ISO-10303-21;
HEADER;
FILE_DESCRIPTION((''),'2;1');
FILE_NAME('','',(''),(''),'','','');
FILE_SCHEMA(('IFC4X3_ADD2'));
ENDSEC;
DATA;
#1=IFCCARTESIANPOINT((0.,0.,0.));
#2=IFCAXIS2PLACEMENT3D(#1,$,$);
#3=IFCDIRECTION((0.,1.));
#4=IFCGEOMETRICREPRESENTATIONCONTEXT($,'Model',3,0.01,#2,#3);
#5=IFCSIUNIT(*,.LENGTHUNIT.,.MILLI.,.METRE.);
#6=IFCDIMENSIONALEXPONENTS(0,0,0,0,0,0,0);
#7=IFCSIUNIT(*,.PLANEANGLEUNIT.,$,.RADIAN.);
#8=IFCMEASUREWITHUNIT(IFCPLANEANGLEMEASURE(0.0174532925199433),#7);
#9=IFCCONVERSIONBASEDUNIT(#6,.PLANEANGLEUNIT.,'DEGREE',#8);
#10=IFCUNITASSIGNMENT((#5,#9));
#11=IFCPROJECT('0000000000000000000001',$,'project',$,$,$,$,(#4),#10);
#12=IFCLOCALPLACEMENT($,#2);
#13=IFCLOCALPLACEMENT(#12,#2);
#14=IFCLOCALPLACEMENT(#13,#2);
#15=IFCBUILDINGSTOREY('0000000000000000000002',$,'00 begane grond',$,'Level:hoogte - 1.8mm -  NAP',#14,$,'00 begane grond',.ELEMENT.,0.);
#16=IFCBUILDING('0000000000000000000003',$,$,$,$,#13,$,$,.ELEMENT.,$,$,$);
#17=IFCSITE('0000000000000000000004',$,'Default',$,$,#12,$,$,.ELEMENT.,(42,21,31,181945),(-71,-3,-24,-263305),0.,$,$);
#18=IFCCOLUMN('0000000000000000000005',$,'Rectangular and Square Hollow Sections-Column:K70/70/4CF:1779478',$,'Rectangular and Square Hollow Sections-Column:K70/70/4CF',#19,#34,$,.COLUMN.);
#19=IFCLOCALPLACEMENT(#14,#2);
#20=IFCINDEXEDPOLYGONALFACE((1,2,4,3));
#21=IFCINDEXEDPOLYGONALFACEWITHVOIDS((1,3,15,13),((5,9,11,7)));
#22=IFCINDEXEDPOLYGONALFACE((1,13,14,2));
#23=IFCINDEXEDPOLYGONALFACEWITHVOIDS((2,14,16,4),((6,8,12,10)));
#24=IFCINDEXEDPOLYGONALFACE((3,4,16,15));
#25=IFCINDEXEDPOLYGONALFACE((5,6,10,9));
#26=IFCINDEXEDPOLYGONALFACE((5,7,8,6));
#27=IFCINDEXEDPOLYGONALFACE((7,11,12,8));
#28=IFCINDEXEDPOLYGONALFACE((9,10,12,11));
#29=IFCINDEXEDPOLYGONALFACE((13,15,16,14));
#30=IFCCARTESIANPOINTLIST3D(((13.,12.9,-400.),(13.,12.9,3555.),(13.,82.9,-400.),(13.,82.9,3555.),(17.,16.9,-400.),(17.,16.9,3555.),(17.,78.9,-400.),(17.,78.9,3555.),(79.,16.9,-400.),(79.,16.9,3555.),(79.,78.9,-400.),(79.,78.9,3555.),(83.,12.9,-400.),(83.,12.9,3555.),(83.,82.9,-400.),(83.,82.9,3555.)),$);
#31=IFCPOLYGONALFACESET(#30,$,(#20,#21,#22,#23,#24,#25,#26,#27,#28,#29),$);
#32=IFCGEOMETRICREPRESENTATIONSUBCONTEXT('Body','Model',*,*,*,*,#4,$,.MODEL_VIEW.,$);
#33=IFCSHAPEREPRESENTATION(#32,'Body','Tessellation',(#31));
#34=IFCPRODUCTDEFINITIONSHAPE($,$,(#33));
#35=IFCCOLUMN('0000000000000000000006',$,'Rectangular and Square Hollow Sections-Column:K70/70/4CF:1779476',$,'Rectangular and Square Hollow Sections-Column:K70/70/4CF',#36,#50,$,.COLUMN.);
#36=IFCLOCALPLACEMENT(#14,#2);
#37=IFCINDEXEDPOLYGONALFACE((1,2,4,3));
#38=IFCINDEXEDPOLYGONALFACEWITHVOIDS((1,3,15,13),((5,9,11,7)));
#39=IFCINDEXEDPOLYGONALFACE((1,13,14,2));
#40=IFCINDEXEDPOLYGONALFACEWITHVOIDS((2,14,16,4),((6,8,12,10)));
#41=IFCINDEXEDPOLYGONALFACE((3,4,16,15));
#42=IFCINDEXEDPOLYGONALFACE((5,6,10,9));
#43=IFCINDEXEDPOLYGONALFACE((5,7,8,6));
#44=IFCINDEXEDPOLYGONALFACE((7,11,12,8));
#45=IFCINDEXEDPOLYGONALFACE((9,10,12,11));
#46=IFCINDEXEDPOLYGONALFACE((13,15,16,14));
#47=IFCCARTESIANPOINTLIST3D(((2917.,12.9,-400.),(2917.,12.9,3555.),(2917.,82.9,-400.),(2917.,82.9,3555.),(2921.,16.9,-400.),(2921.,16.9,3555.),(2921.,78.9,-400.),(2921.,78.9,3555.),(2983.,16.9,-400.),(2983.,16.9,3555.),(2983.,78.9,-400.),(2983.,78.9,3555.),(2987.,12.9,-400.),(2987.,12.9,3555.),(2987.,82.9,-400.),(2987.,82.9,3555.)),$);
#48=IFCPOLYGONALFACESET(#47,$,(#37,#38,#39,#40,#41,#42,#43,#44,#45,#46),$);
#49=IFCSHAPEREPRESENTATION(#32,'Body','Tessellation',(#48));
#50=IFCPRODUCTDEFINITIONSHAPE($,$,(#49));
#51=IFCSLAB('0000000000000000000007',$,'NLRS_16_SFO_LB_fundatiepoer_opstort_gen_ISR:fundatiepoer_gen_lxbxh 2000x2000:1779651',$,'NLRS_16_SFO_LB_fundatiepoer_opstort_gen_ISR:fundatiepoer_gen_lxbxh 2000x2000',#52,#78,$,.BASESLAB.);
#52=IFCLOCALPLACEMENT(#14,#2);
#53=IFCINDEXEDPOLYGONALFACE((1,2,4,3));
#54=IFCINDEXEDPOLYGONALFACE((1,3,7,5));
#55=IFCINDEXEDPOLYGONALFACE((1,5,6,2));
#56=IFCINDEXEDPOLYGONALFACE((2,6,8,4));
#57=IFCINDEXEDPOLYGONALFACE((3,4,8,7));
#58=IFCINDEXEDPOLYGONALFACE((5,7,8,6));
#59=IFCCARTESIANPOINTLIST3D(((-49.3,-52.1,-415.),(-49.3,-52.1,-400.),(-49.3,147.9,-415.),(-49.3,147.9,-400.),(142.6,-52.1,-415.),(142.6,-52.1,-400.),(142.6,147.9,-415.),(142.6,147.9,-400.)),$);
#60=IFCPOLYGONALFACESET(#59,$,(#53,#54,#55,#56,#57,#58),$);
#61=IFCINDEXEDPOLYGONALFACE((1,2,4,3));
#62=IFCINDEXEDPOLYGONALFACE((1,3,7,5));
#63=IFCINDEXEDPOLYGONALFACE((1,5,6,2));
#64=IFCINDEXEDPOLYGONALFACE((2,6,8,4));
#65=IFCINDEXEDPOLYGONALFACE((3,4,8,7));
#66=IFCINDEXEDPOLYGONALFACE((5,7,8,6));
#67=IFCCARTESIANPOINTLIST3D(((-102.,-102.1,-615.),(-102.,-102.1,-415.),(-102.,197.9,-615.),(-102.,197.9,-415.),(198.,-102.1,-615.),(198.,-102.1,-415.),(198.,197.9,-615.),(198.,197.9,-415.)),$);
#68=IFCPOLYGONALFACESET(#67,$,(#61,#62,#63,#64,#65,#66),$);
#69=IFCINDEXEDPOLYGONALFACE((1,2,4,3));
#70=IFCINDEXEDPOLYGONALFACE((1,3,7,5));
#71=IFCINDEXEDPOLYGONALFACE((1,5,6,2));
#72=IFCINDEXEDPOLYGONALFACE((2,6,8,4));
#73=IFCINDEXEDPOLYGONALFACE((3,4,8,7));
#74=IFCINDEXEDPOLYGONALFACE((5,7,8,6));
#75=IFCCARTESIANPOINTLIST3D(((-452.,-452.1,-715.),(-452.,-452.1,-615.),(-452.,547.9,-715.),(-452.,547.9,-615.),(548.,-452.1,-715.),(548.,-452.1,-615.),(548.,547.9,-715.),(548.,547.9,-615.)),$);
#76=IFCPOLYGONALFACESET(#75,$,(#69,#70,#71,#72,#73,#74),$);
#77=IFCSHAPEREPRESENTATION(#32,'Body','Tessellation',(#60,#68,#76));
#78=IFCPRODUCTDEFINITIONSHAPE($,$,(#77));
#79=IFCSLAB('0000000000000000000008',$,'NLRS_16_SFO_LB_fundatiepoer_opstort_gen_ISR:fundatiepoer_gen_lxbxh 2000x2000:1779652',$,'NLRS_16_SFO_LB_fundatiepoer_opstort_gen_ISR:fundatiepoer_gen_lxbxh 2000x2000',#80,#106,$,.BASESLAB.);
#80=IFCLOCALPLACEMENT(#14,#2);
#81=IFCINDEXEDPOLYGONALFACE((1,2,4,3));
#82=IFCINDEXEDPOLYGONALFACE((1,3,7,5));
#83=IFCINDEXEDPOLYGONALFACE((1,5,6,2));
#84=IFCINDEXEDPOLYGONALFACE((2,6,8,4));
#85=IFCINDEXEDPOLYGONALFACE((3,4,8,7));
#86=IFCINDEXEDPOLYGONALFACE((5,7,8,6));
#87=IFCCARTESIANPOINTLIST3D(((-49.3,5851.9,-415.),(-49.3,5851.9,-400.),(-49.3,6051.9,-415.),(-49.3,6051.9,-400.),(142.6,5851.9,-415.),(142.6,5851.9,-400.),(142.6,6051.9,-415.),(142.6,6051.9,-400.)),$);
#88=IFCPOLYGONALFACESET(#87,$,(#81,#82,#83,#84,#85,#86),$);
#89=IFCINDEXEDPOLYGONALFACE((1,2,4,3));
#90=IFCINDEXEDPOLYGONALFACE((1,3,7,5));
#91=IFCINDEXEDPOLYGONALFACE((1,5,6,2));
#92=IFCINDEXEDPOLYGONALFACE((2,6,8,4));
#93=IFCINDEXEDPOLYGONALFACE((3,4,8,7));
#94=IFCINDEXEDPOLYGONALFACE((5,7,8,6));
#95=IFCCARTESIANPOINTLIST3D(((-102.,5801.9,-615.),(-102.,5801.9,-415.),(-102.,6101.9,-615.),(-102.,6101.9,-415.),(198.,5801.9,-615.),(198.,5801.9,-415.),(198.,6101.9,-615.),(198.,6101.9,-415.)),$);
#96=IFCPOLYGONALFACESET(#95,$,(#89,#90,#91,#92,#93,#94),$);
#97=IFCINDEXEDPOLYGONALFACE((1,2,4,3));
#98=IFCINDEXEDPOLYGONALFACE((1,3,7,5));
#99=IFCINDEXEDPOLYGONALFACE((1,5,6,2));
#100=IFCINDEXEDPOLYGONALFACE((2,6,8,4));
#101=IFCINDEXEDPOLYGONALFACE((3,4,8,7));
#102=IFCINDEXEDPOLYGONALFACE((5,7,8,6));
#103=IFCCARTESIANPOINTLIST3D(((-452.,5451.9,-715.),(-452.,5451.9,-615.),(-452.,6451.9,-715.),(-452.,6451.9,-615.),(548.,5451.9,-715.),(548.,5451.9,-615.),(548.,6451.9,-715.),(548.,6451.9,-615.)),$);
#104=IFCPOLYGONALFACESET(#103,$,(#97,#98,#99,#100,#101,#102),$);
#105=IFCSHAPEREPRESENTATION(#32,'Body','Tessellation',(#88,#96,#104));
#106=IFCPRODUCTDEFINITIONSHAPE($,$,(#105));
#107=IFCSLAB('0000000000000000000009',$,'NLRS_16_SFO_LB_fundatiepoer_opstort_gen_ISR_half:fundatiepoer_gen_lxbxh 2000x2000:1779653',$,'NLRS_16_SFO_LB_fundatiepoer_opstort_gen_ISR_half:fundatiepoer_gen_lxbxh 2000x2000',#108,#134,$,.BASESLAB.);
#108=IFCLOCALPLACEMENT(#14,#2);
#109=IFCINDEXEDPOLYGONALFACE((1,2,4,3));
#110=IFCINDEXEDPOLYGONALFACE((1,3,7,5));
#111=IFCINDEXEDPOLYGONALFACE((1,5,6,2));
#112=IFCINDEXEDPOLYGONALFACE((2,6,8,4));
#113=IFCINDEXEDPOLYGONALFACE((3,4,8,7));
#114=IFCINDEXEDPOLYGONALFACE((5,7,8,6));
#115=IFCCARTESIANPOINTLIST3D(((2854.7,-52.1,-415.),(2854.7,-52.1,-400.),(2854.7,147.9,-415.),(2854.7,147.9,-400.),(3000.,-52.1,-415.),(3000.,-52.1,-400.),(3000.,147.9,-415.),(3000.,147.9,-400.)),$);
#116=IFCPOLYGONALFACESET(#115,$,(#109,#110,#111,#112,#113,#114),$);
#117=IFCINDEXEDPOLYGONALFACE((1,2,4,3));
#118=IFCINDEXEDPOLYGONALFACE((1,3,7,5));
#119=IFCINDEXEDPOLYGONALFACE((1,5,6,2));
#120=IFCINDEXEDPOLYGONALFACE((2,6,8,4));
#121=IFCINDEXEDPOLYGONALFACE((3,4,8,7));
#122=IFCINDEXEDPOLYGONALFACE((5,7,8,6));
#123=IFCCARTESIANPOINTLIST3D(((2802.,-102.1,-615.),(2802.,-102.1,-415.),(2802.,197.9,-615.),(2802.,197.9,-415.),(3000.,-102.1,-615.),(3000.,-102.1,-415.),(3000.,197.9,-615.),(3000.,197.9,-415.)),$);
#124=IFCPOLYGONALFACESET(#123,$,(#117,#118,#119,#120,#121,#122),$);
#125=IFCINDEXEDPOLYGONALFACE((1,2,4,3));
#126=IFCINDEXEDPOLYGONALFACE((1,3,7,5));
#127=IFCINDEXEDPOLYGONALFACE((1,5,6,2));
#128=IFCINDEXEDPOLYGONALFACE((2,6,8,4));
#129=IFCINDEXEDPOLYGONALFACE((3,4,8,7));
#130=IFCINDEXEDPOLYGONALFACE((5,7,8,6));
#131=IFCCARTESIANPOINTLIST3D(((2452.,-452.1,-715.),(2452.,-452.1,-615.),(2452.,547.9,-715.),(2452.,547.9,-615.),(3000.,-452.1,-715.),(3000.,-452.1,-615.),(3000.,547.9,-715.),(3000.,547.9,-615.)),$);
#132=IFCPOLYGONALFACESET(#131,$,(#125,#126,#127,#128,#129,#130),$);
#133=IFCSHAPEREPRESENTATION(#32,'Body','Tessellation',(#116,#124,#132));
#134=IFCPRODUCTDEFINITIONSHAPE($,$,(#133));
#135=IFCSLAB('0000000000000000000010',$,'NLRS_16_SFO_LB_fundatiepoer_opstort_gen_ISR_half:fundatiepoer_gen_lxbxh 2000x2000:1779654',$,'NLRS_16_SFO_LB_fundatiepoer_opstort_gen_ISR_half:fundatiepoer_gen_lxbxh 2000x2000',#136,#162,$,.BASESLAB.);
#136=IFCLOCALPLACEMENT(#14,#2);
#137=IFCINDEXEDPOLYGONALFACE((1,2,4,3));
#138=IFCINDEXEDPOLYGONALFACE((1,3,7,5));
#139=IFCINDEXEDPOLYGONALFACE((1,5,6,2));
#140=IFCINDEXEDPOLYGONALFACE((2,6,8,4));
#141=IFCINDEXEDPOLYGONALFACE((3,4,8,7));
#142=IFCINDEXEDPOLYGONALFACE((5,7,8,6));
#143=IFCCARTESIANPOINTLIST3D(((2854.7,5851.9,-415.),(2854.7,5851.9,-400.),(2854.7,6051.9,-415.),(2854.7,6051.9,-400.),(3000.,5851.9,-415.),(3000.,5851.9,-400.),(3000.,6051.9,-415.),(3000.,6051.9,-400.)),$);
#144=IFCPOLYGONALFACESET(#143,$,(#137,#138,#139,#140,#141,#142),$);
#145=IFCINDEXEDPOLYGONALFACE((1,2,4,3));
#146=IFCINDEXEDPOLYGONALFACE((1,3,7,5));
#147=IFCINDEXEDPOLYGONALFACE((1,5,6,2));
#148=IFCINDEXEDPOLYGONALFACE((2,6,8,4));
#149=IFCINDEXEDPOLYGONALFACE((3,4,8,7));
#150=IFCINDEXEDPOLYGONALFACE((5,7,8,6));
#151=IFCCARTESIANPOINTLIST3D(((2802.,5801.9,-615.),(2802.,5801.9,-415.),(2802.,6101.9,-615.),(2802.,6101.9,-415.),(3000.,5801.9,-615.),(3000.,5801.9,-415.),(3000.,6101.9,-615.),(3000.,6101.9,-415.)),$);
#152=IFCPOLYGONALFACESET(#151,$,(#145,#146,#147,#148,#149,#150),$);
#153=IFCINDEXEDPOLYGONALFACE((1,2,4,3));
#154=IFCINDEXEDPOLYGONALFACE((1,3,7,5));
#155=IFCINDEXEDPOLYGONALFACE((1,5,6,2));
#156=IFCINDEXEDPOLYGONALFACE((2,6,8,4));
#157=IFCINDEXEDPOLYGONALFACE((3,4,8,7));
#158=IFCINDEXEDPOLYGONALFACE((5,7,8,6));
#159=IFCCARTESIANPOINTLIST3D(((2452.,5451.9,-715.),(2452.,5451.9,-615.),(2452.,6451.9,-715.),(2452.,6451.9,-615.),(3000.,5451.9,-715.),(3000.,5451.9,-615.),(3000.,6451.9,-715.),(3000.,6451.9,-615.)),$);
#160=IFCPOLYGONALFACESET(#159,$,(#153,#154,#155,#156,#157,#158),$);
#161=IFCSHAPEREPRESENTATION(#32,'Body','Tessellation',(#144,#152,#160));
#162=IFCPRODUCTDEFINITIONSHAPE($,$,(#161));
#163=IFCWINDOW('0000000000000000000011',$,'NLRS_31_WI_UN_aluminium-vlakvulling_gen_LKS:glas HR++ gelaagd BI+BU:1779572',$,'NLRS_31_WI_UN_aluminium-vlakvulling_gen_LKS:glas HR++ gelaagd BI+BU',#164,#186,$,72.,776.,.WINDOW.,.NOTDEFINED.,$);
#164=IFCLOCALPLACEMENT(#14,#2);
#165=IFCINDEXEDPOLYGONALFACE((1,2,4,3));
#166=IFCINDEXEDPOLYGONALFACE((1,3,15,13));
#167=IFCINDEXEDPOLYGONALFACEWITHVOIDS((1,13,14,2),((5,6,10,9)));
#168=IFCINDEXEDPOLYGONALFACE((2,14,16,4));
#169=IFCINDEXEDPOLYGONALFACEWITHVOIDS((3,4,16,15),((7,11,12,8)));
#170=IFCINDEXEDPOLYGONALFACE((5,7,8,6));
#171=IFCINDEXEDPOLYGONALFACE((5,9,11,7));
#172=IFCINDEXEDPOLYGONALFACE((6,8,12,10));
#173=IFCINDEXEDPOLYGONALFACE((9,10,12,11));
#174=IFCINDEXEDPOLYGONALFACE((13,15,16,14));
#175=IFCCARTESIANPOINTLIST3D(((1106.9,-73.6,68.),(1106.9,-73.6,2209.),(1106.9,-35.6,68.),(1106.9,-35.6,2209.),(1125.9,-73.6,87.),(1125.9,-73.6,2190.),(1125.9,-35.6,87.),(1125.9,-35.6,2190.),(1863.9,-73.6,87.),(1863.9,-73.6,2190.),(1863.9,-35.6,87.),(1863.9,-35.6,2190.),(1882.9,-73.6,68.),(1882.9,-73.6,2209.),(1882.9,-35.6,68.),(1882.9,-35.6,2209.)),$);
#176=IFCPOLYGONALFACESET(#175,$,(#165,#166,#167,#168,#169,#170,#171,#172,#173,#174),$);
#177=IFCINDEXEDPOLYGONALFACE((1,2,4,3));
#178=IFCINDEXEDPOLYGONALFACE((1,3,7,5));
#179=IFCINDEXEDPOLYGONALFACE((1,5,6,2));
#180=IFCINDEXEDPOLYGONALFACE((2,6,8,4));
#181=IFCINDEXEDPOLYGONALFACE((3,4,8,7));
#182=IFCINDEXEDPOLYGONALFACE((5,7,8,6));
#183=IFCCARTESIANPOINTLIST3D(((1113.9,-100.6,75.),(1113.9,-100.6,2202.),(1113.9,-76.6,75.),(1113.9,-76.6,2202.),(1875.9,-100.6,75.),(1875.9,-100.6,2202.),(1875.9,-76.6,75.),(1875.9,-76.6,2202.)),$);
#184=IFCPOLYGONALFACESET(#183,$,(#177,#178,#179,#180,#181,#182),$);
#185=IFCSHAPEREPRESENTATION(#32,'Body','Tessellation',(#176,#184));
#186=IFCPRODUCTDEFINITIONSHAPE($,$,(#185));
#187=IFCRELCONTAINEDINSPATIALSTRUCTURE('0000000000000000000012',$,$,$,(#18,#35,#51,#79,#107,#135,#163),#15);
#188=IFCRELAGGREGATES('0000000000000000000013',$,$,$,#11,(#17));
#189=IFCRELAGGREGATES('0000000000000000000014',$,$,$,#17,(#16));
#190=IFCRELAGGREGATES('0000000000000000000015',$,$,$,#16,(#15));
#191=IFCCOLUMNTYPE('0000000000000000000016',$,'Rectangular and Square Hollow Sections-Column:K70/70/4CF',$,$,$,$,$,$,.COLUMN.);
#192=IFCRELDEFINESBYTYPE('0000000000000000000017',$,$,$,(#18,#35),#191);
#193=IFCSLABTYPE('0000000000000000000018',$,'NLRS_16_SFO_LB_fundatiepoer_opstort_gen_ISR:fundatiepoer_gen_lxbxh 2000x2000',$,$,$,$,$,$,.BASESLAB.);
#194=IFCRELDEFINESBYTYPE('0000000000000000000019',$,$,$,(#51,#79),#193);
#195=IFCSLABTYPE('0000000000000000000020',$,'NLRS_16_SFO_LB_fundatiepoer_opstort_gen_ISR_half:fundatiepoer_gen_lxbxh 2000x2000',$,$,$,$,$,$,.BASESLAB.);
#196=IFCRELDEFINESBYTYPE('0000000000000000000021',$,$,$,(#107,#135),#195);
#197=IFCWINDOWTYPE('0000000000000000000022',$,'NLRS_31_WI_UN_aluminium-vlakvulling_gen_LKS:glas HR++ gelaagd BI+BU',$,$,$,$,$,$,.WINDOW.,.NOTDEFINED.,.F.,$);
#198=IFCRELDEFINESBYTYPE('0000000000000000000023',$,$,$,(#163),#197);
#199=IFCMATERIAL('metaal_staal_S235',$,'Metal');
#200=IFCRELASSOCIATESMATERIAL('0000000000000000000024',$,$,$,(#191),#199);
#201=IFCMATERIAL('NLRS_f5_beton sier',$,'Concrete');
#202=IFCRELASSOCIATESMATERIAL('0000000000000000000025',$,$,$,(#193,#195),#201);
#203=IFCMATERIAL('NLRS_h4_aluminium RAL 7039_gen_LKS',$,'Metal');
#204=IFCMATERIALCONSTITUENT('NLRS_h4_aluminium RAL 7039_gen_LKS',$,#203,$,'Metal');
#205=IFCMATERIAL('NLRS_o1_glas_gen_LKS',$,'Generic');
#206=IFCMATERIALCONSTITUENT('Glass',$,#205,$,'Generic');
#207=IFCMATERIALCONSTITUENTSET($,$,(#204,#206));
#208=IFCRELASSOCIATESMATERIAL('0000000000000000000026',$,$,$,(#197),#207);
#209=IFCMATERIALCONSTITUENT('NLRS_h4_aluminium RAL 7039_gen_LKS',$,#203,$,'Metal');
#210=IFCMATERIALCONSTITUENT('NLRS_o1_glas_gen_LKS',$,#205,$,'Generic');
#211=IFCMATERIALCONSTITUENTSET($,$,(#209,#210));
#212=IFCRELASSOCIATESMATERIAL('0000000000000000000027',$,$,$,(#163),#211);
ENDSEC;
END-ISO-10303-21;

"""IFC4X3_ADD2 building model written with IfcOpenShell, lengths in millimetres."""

from ifc_helpers import new_model, entity, si_unit, converted_unit, direction, frame, frame_2d, origin, origin_2d_with_axis, place, context, subcontext, project, spatial, polyline, rectangle, outline, extrude, source, transform, mapped, material, constituent, constituent_set, material_profile, profile_set, type_object, type_shapes, element, save


model = new_model("IFC4X3_ADD2")

# Units and contexts
model_context = context("Model", 3, precision=0.01, world=origin(), true_north=direction((0.0, 1.0)))
body_context = subcontext(model_context, "Body", "Model", "MODEL_VIEW")
ifc_project = project(units=[si_unit("LENGTHUNIT", "METRE", prefix="MILLI"), converted_unit("PLANEANGLEUNIT", "DEGREE", entity("IfcPlaneAngleMeasure", 0.0174532925199433), si_unit("PLANEANGLEUNIT", "RADIAN"), dimensions=[0, 0, 0, 0, 0, 0, 0])], contexts=[model_context])

# Site, building, storey
site_placement = place(None, origin())
site = spatial("IfcSite", under=ifc_project, at=site_placement, Name="Default", CompositionType="ELEMENT", RefLatitude=(42, 21, 31, 181945), RefLongitude=(-71, -3, -24, -263305), RefElevation=0.0)
building_placement = place(site_placement, origin())
building = spatial("IfcBuilding", under=site, at=building_placement, CompositionType="ELEMENT")
storey_placement = place(building_placement, origin())
storey = spatial("IfcBuildingStorey", under=building, at=storey_placement, Name="00 begane grond", ObjectType="Level:hoogte - 1.8mm -  NAP", LongName="00 begane grond", CompositionType="ELEMENT", Elevation=0.0)

# Columns
ifc_material_1 = material(Name="metaal_staal_S235", Category="Metal")
ifc_material_profile_1 = material_profile(ifc_material_1, outline(polyline([(-35.0, -35.0), (35.0, -35.0), (35.0, 35.0), (-35.0, 35.0), (-35.0, -35.0)]), holes=[polyline([(-31.0, -31.0), (-31.0, 31.0), (31.0, 31.0), (31.0, -31.0), (-31.0, -31.0)])]), Name="K70/70/4CF")
ifc_profile_set_1 = profile_set([ifc_material_profile_1], Name="K70/70/4CF")
column_type = type_object("IfcColumnType", Name="Rectangular and Square Hollow Sections-Column:K70/70/4CF", PredefinedType="COLUMN", material=ifc_profile_set_1)
shared_shape_1 = source(origin(), body_context, "Body", "SweptSolid", [
    extrude(outline(polyline([(-35.0, -35.0), (35.0, -35.0), (35.0, 35.0), (-35.0, 35.0), (-35.0, -35.0)]), holes=[polyline([(-31.0, -31.0), (-31.0, 31.0), (31.0, 31.0), (31.0, -31.0), (-31.0, -31.0)])]), frame((0.0, 0.0, -400.0), z_axis=(0.0, 0.0, 1.0), x_axis=(-1.0, 0.0, 0.0)), (0.0, 0.0, 1.0), 3955.0),
])
type_shapes(column_type, [shared_shape_1])
for number, where, z_axis, x_axis, name in (
    (1, (48.0, 47.9, 0.0), (0.0, 0.0, 1.0), (0.0, -1.0, 0.0), "Rectangular and Square Hollow Sections-Column:K70/70/4CF:1779478"),
    (2, (2952.0, 47.9, 0.0), (0.0, 0.0, 1.0), (0.0, -1.0, 0.0), "Rectangular and Square Hollow Sections-Column:K70/70/4CF:1779476"),
):
    element("IfcColumn", number, at=place(storey_placement, frame(where, z_axis=z_axis, x_axis=x_axis)), inside=storey, type_object=column_type, Name=name, ObjectType="Rectangular and Square Hollow Sections-Column:K70/70/4CF", PredefinedType="COLUMN", context=body_context, shape_type="MappedRepresentation", body=[
        mapped(shared_shape_1, transform((0.0, 0.0, 0.0), scale=1.0)),
    ])

# Slabs
ifc_material_2 = material(Name="NLRS_f5_beton sier", Category="Concrete")
slab_type_1 = type_object("IfcSlabType", Name="NLRS_16_SFO_LB_fundatiepoer_opstort_gen_ISR:fundatiepoer_gen_lxbxh 2000x2000", PredefinedType="BASESLAB", material=ifc_material_2)
slab_1_placement = place(storey_placement, frame((0.0, 0.0, -615.0)))
element("IfcSlab", 3, at=slab_1_placement, inside=storey, type_object=slab_type_1, Name="NLRS_16_SFO_LB_fundatiepoer_opstort_gen_ISR:fundatiepoer_gen_lxbxh 2000x2000:1779651", ObjectType="NLRS_16_SFO_LB_fundatiepoer_opstort_gen_ISR:fundatiepoer_gen_lxbxh 2000x2000", PredefinedType="BASESLAB", context=body_context, shape_type="SweptSolid", body=[
    extrude(rectangle(XDim=191.9, YDim=200.0, at=origin_2d_with_axis()), frame((46.6, 47.9, 200.0), z_axis=(0.0, 0.0, 1.0), x_axis=(-1.0, 0.0, 0.0)), (0.0, 0.0, 1.0), 15.0),
    extrude(rectangle(XDim=300.0, YDim=300.0, at=origin_2d_with_axis()), frame((48.0, 47.9, 0.0), z_axis=(0.0, 0.0, 1.0), x_axis=(-1.0, 0.0, 0.0)), (0.0, 0.0, 1.0), 200.0),
    extrude(rectangle(XDim=1000.0, YDim=1000.0, at=origin_2d_with_axis()), frame((48.0, 47.9, -100.0), z_axis=(0.0, 0.0, 1.0), x_axis=(-1.0, 0.0, 0.0)), (0.0, 0.0, 1.0), 100.0),
])
slab_2_placement = place(storey_placement, frame((0.0, 0.0, -615.0)))
element("IfcSlab", 4, at=slab_2_placement, inside=storey, type_object=slab_type_1, Name="NLRS_16_SFO_LB_fundatiepoer_opstort_gen_ISR:fundatiepoer_gen_lxbxh 2000x2000:1779652", ObjectType="NLRS_16_SFO_LB_fundatiepoer_opstort_gen_ISR:fundatiepoer_gen_lxbxh 2000x2000", PredefinedType="BASESLAB", context=body_context, shape_type="SweptSolid", body=[
    extrude(rectangle(XDim=200.0, YDim=191.9, at=frame_2d((0.0, 0.0), x_axis=(1.0, 0.0))), frame((46.6, 5951.9, 200.0), z_axis=(0.0, 0.0, 1.0), x_axis=(0.0, 1.0, 0.0)), (0.0, 0.0, 1.0), 15.0),
    extrude(rectangle(XDim=300.0, YDim=300.0, at=frame_2d((0.0, 0.0), x_axis=(1.0, 0.0))), frame((48.0, 5951.9, 0.0), z_axis=(0.0, 0.0, 1.0), x_axis=(0.0, 1.0, 0.0)), (0.0, 0.0, 1.0), 200.0),
    extrude(rectangle(XDim=1000.0, YDim=1000.0, at=frame_2d((0.0, 0.0), x_axis=(1.0, 0.0))), frame((48.0, 5951.9, -100.0), z_axis=(0.0, 0.0, 1.0), x_axis=(0.0, 1.0, 0.0)), (0.0, 0.0, 1.0), 100.0),
])
slab_type_2 = type_object("IfcSlabType", Name="NLRS_16_SFO_LB_fundatiepoer_opstort_gen_ISR_half:fundatiepoer_gen_lxbxh 2000x2000", PredefinedType="BASESLAB", material=ifc_material_2)
slab_3_placement = place(storey_placement, frame((0.0, 0.0, -615.0)))
element("IfcSlab", 5, at=slab_3_placement, inside=storey, type_object=slab_type_2, Name="NLRS_16_SFO_LB_fundatiepoer_opstort_gen_ISR_half:fundatiepoer_gen_lxbxh 2000x2000:1779653", ObjectType="NLRS_16_SFO_LB_fundatiepoer_opstort_gen_ISR_half:fundatiepoer_gen_lxbxh 2000x2000", PredefinedType="BASESLAB", context=body_context, shape_type="SweptSolid", body=[
    extrude(rectangle(XDim=145.3, YDim=200.0, at=frame_2d((0.0, 0.0), x_axis=(1.0, 0.0))), frame((2927.3, 47.9, 200.0)), (0.0, 0.0, 1.0), 15.0),
    extrude(rectangle(XDim=198.0, YDim=300.0, at=origin_2d_with_axis()), frame((2901.0, 47.9, 0.0)), (0.0, 0.0, 1.0), 200.0),
    extrude(rectangle(XDim=548.0, YDim=1000.0, at=frame_2d((0.0, 0.0), x_axis=(1.0, 0.0))), frame((2726.0, 47.9, -100.0)), (0.0, 0.0, 1.0), 100.0),
])
slab_4_placement = place(storey_placement, frame((0.0, 0.0, -615.0)))
element("IfcSlab", 6, at=slab_4_placement, inside=storey, type_object=slab_type_2, Name="NLRS_16_SFO_LB_fundatiepoer_opstort_gen_ISR_half:fundatiepoer_gen_lxbxh 2000x2000:1779654", ObjectType="NLRS_16_SFO_LB_fundatiepoer_opstort_gen_ISR_half:fundatiepoer_gen_lxbxh 2000x2000", PredefinedType="BASESLAB", context=body_context, shape_type="SweptSolid", body=[
    extrude(rectangle(XDim=200.0, YDim=145.3, at=frame_2d((0.0, 0.0), x_axis=(1.0, 0.0))), frame((2927.3, 5951.9, 200.0), z_axis=(0.0, 0.0, 1.0), x_axis=(0.0, -1.0, 0.0)), (0.0, 0.0, 1.0), 15.0),
    extrude(rectangle(XDim=300.0, YDim=198.0, at=frame_2d((0.0, 0.0), x_axis=(1.0, 0.0))), frame((2901.0, 5951.9, 0.0), z_axis=(0.0, 0.0, 1.0), x_axis=(0.0, -1.0, 0.0)), (0.0, 0.0, 1.0), 200.0),
    extrude(rectangle(XDim=1000.0, YDim=548.0, at=frame_2d((0.0, 0.0), x_axis=(1.0, 0.0))), frame((2726.0, 5951.9, -100.0), z_axis=(0.0, 0.0, 1.0), x_axis=(0.0, -1.0, 0.0)), (0.0, 0.0, 1.0), 100.0),
])

# Window
ifc_material_3 = material(Name="NLRS_h4_aluminium RAL 7039_gen_LKS", Category="Metal")
ifc_constituent_1 = constituent(ifc_material_3, Name="NLRS_h4_aluminium RAL 7039_gen_LKS", Category="Metal")
ifc_material_4 = material(Name="NLRS_o1_glas_gen_LKS", Category="Generic")
ifc_constituent_2 = constituent(ifc_material_4, Name="NLRS_o1_glas_gen_LKS", Category="Generic")
ifc_constituent_set_1 = constituent_set(constituents=[ifc_constituent_1, ifc_constituent_2])
ifc_constituent_3 = constituent(ifc_material_3, Name="NLRS_h4_aluminium RAL 7039_gen_LKS", Category="Metal")
ifc_constituent_4 = constituent(ifc_material_4, Name="Glass", Category="Generic")
ifc_constituent_set_2 = constituent_set(constituents=[ifc_constituent_3, ifc_constituent_4])
window_type = type_object("IfcWindowType", Name="NLRS_31_WI_UN_aluminium-vlakvulling_gen_LKS:glas HR++ gelaagd BI+BU", ParameterTakesPrecedence=False, PartitioningType="NOTDEFINED", PredefinedType="WINDOW", material=ifc_constituent_set_2)
shared_shape_2 = source(origin(), body_context, "Body", "SweptSolid", [
    extrude(outline(polyline([(-1070.5, -388.0), (1070.5, -388.0), (1070.5, 388.0), (-1070.5, 388.0), (-1070.5, -388.0)]), holes=[polyline([(1051.5, -369.0), (-1051.5, -369.0), (-1051.5, 369.0), (1051.5, 369.0), (1051.5, -369.0)])]), frame((0.0, 34.0, 1070.5), z_axis=(0.0, 1.0, 0.0), x_axis=(0.0, 0.0, -1.0)), (0.0, 0.0, 1.0), 38.0),
    extrude(rectangle(XDim=24.0, YDim=762.0, at=frame_2d((0.0, 0.0), x_axis=(1.0, 0.0))), frame((0.0, 19.0, 7.0), z_axis=(0.0, 0.0, 1.0), x_axis=(0.0, -1.0, 0.0)), (0.0, 0.0, 1.0), 2127.0),
])
type_shapes(window_type, [shared_shape_2])
window_placement = place(storey_placement, frame((1494.9, -107.6, 68.0)))
element("IfcWindow", 7, at=window_placement, inside=storey, type_object=window_type, material=ifc_constituent_set_1, Name="NLRS_31_WI_UN_aluminium-vlakvulling_gen_LKS:glas HR++ gelaagd BI+BU:1779572", ObjectType="NLRS_31_WI_UN_aluminium-vlakvulling_gen_LKS:glas HR++ gelaagd BI+BU", OverallHeight=72.0, OverallWidth=776.0, PartitioningType="NOTDEFINED", PredefinedType="WINDOW", context=body_context, shape_type="MappedRepresentation", body=[
    mapped(shared_shape_2, transform((0.0, 0.0, 0.0), scale=1.0)),
])

save(model, "model.ifc")
